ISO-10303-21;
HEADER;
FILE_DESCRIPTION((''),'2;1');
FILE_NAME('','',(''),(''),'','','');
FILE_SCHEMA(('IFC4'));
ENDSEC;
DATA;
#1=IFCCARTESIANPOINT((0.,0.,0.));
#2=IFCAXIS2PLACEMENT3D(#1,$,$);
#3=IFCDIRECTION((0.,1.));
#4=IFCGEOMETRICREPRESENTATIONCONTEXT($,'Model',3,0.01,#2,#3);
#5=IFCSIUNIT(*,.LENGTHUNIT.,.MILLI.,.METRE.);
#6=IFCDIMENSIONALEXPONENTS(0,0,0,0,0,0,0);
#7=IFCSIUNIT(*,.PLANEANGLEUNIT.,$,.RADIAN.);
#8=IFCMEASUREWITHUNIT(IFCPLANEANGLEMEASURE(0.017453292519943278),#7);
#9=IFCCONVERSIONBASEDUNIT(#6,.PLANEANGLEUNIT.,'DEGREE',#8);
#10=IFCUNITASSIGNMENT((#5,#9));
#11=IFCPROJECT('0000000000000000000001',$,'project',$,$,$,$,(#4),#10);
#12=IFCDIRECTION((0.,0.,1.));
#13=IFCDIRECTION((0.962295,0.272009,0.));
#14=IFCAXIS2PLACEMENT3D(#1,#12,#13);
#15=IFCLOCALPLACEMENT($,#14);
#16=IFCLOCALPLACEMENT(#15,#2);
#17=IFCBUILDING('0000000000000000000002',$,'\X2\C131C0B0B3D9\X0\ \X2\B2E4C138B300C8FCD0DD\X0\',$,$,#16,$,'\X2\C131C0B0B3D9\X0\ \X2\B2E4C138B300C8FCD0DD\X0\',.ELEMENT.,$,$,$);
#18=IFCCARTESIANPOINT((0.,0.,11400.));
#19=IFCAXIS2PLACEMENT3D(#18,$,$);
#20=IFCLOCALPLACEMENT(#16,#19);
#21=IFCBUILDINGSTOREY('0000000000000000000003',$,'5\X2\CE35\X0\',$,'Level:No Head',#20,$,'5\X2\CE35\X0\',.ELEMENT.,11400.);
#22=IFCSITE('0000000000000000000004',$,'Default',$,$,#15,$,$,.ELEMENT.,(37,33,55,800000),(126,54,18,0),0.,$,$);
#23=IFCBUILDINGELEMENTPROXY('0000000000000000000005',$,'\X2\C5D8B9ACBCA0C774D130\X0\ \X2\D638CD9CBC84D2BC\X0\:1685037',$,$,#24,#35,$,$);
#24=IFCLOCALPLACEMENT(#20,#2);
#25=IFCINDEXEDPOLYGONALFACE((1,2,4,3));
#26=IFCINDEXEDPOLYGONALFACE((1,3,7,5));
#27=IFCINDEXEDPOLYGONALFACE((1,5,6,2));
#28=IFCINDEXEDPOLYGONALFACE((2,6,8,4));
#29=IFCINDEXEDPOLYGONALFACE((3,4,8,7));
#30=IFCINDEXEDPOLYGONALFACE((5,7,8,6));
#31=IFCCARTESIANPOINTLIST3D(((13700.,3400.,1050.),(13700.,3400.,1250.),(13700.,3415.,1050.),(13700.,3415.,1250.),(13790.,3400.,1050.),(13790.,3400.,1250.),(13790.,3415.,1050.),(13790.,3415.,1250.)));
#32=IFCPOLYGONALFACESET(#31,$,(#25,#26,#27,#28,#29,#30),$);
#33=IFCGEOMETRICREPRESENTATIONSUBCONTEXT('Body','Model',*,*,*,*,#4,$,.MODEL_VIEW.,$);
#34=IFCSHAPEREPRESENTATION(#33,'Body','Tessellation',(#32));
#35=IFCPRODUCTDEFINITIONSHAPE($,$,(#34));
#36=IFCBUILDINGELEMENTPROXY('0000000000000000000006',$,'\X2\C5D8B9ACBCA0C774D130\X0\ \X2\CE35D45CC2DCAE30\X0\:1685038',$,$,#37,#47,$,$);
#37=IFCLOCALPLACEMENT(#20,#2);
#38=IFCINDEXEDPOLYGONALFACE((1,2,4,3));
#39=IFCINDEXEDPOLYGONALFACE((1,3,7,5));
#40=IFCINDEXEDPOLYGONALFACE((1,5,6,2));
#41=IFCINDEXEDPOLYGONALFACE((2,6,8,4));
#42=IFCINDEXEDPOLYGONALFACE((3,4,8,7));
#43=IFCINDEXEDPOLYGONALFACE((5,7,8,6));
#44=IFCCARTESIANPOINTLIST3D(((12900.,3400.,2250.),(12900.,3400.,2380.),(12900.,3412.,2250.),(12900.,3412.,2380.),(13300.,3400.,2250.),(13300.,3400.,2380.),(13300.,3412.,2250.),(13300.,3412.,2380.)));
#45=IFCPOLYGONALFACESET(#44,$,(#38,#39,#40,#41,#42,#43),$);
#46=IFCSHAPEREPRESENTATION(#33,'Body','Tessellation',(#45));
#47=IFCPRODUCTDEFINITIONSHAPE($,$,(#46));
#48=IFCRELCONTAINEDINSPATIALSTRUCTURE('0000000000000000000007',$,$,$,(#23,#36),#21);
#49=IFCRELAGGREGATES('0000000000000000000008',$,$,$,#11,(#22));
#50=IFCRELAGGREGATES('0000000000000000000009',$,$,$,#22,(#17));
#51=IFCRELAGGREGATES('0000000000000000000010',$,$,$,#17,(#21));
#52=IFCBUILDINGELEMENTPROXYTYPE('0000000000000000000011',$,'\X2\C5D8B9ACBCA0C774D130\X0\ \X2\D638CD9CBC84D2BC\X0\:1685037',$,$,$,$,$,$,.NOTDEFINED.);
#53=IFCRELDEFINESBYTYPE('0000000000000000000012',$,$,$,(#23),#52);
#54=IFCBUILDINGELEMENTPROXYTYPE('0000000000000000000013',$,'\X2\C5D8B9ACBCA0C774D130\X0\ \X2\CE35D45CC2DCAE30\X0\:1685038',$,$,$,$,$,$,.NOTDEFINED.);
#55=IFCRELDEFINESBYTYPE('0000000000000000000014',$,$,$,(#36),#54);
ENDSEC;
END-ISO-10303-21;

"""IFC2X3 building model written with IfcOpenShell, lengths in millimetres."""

from ifc_helpers import new_model, entity, si_unit, converted_unit, direction, frame, frame_2d, origin, place, context, subcontext, project, spatial, rectangle, extrude, type_object, element, save


model = new_model("IFC2X3")

# Units and contexts
model_context = context("Model", 3, precision=0.01, world=origin(), true_north=direction((0.0, 1.0)))
body_context = subcontext(model_context, "Body", "Model", "MODEL_VIEW")
ifc_project = project(units=[si_unit("LENGTHUNIT", "METRE", prefix="MILLI"), converted_unit("PLANEANGLEUNIT", "DEGREE", entity("IfcPlaneAngleMeasure", 0.017453292519943278), si_unit("PLANEANGLEUNIT", "RADIAN"), dimensions=[0, 0, 0, 0, 0, 0, 0])], contexts=[model_context])

# Site, building, storey
site_placement = place(None, frame((0.0, 0.0, 0.0), z_axis=(0.0, 0.0, 1.0), x_axis=(0.962295, 0.272009, 0.0)))
site = spatial("IfcSite", under=ifc_project, at=site_placement, Name="Default", CompositionType="ELEMENT", RefLatitude=(37, 33, 55, 800000), RefLongitude=(126, 54, 18, 0), RefElevation=0.0)
building_placement = place(site_placement, origin())
building = spatial("IfcBuilding", under=site, at=building_placement, Name="성산동 다세대주택", LongName="성산동 다세대주택", CompositionType="ELEMENT")
storey_placement = place(building_placement, frame((0.0, 0.0, 11400.0)))
storey = spatial("IfcBuildingStorey", under=building, at=storey_placement, Name="5층", ObjectType="Level:No Head", LongName="5층", CompositionType="ELEMENT", Elevation=11400.0)

# Building element proxies
building_element_proxy_type_1 = type_object("IfcBuildingElementProxyType", Name="엘리베이터 호출버튼:1685037", PredefinedType="NOTDEFINED")
proxy_1_placement = place(storey_placement, origin())
element("IfcBuildingElementProxy", 1, at=proxy_1_placement, inside=storey, type_object=building_element_proxy_type_1, Name="엘리베이터 호출버튼:1685037", context=body_context, shape_type="SweptSolid", body=[
    extrude(rectangle(XDim=90.0, YDim=15.0, at=frame_2d((0.0, 0.0), x_axis=(1.0, 0.0))), frame((13745.0, 3407.5, 1050.0)), (0.0, 0.0, 1.0), 200.0),
])
building_element_proxy_type_2 = type_object("IfcBuildingElementProxyType", Name="엘리베이터 층표시기:1685038", PredefinedType="NOTDEFINED")
proxy_2_placement = place(storey_placement, origin())
element("IfcBuildingElementProxy", 2, at=proxy_2_placement, inside=storey, type_object=building_element_proxy_type_2, Name="엘리베이터 층표시기:1685038", context=body_context, shape_type="SweptSolid", body=[
    extrude(rectangle(XDim=400.0, YDim=12.0, at=frame_2d((0.0, 0.0), x_axis=(1.0, 0.0))), frame((13100.0, 3406.0, 2250.0)), (0.0, 0.0, 1.0), 130.0),
])

save(model, "model.ifc")
